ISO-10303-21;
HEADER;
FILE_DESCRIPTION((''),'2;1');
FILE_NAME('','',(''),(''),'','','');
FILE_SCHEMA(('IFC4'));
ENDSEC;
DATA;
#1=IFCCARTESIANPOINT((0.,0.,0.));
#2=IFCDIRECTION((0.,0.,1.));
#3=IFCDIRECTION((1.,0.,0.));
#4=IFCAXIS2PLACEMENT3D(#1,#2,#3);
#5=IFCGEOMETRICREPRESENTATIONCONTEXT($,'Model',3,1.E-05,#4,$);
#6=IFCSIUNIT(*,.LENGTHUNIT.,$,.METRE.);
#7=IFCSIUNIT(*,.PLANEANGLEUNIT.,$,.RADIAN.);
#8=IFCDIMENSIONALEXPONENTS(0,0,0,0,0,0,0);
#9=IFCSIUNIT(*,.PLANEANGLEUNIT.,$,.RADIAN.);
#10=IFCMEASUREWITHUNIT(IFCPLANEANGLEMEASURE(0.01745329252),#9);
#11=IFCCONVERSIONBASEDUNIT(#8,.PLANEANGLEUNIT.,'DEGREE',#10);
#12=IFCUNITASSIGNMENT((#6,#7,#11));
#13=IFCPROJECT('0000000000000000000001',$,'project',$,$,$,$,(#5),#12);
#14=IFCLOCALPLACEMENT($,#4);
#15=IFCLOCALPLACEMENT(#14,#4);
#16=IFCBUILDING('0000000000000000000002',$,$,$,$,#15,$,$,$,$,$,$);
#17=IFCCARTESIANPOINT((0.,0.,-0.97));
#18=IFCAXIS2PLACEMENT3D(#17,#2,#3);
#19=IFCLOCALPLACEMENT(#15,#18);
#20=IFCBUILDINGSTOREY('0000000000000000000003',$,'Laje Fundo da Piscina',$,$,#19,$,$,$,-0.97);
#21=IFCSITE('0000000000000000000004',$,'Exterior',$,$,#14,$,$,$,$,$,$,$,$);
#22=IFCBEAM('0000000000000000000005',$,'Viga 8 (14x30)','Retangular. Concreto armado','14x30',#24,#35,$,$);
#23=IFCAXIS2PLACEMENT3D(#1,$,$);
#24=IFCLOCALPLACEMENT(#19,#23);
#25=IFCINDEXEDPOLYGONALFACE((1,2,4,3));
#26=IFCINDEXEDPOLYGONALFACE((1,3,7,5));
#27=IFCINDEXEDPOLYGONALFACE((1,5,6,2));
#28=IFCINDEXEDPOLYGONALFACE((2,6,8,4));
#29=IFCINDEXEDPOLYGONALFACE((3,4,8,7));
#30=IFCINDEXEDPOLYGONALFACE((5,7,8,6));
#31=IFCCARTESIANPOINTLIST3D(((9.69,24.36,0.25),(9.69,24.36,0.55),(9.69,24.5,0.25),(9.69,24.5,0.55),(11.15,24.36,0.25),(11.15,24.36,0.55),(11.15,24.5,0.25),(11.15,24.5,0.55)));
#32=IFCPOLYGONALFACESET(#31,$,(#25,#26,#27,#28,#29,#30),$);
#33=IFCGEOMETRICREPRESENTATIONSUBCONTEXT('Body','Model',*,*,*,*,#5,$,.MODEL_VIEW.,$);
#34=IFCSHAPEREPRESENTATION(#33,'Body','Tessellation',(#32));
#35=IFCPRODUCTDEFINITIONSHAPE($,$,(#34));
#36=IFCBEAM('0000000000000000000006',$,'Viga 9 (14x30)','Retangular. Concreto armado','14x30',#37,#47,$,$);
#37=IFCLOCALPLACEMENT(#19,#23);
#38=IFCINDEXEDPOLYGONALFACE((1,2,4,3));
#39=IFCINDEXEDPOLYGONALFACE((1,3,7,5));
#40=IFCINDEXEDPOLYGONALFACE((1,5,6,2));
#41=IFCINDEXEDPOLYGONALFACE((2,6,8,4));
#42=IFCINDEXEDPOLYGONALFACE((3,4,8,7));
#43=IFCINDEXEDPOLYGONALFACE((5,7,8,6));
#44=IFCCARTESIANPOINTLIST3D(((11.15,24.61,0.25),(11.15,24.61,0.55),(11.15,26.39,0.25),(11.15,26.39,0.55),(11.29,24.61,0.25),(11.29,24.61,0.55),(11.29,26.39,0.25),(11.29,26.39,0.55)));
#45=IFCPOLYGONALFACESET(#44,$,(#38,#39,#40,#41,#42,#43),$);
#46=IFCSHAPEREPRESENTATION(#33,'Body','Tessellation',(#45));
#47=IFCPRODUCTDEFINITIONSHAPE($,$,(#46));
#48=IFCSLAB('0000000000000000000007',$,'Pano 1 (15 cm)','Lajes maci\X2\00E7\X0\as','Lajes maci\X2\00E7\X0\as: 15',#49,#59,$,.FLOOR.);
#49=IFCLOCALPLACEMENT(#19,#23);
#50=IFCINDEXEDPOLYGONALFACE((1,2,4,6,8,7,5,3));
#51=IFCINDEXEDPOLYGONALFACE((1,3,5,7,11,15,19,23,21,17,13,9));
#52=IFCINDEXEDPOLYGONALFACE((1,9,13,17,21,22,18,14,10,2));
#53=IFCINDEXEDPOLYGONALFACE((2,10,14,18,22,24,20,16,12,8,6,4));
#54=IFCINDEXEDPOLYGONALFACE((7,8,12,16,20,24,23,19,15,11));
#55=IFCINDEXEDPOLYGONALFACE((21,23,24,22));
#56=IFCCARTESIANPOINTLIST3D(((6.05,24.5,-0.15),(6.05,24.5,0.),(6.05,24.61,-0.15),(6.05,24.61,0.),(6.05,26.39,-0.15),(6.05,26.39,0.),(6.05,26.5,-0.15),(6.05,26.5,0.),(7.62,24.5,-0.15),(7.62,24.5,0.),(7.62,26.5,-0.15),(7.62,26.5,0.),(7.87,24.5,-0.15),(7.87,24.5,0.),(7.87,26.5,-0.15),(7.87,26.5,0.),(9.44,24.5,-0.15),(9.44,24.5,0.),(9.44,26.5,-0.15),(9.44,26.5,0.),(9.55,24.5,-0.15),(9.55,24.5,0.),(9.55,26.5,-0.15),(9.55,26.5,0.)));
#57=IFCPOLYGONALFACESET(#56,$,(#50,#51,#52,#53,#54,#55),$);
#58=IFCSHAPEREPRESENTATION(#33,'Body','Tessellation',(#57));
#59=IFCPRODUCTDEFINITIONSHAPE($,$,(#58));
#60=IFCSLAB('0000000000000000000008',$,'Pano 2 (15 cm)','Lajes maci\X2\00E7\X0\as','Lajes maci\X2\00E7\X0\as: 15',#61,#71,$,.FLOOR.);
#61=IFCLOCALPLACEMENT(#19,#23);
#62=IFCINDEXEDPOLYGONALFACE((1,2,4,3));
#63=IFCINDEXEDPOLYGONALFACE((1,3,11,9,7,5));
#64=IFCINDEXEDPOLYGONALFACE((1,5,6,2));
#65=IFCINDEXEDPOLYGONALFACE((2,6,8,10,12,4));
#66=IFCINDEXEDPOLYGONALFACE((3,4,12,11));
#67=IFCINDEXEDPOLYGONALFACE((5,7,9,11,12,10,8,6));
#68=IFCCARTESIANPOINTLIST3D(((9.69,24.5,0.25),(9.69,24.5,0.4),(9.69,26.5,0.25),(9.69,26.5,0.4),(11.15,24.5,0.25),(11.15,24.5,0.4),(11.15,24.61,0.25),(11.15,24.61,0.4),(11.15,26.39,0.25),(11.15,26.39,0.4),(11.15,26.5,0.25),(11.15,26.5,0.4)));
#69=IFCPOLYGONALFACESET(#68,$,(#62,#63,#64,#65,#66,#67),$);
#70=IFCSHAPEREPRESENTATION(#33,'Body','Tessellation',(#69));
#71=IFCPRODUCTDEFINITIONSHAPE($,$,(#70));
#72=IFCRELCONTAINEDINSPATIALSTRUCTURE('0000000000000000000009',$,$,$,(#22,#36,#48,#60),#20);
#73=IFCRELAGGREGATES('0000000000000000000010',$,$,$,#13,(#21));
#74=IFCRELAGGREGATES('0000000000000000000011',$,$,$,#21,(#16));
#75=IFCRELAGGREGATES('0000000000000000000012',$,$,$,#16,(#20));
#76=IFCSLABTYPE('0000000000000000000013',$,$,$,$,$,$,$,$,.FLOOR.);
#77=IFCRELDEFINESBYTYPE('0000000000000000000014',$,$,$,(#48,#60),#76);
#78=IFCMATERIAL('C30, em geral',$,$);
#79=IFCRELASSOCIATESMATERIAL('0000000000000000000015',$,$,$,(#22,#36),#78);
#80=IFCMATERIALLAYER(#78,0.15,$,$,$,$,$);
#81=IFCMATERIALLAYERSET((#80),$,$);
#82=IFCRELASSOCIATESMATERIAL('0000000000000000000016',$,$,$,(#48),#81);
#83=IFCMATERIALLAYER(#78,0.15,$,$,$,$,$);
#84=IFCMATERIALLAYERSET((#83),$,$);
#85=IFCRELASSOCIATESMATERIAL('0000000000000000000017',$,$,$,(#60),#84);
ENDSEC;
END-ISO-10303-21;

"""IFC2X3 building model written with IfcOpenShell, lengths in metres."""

from ifc_helpers import new_model, entity, si_unit, converted_unit, frame, frame_2d, origin_with_axes, place, context, subcontext, project, spatial, polyline, rectangle, outline, extrude, material, layer, layer_set, layer_usage, type_object, element, save


model = new_model("IFC2X3")

# Units and contexts
model_context = context("Model", 3, precision=1e-05, world=origin_with_axes())
body_context = subcontext(model_context, "Body", "Model", "MODEL_VIEW")
ifc_project = project(units=[si_unit("LENGTHUNIT", "METRE"), si_unit("PLANEANGLEUNIT", "RADIAN"), converted_unit("PLANEANGLEUNIT", "DEGREE", entity("IfcPlaneAngleMeasure", 0.01745329252), si_unit("PLANEANGLEUNIT", "RADIAN"), dimensions=[0, 0, 0, 0, 0, 0, 0])], contexts=[model_context])

# Site, building, storey
site_placement = place(None, origin_with_axes())
site = spatial("IfcSite", under=ifc_project, at=site_placement, Name="Exterior")
building_placement = place(site_placement, origin_with_axes())
building = spatial("IfcBuilding", under=site, at=building_placement)
storey_placement = place(building_placement, frame((0.0, 0.0, -0.97), z_axis=(0.0, 0.0, 1.0), x_axis=(1.0, 0.0, 0.0)))
storey = spatial("IfcBuildingStorey", under=building, at=storey_placement, Name="Laje Fundo da Piscina", Elevation=-0.97)

# Beams
ifc_material_1 = material(Name="C30, em geral")
for number, where, z_axis, x_axis, name in (
    (1, (9.69, 24.43, 0.55), (1.0, 0.0, 0.0), (0.0, 1.0, 0.0), "Viga 8 (14x30)"),
):
    element("IfcBeam", number, at=place(storey_placement, frame(where, z_axis=z_axis, x_axis=x_axis)), inside=storey, material=ifc_material_1, Name=name, Description="Retangular. Concreto armado", ObjectType="14x30", context=body_context, shape_type="SweptSolid", body=[
        extrude(rectangle(XDim=0.14, YDim=0.3, at=frame_2d((0.0, -0.15), x_axis=(1.0, 0.0))), origin_with_axes(), (0.0, 0.0, 1.0), 1.46),
    ])
beam_1_placement = place(storey_placement, frame((11.22, 26.39, 0.55), z_axis=(0.0, -1.0, 0.0), x_axis=(1.0, 0.0, 0.0)))
element("IfcBeam", 2, at=beam_1_placement, inside=storey, material=ifc_material_1, Name="Viga 9 (14x30)", Description="Retangular. Concreto armado", ObjectType="14x30", context=body_context, shape_type="SweptSolid", body=[
    extrude(rectangle(XDim=0.14, YDim=0.3, at=frame_2d((0.0, -0.15), x_axis=(1.0, 0.0))), origin_with_axes(), (0.0, 0.0, 1.0), 1.78),
])

# Slabs
ifc_layer_1 = layer(ifc_material_1, 0.15)
ifc_layer_set_1 = layer_set([ifc_layer_1])
ifc_layer_usage_1 = layer_usage(ifc_layer_set_1, "AXIS3", "POSITIVE", 0.0)
slab_type = type_object("IfcSlabType", PredefinedType="FLOOR")
slab_1_placement = place(storey_placement, frame((0.0, 0.0, -0.15), z_axis=(0.0, 0.0, 1.0), x_axis=(1.0, 0.0, 0.0)))
element("IfcSlab", 3, at=slab_1_placement, inside=storey, type_object=slab_type, material=ifc_layer_usage_1, Name="Pano 1 (15 cm)", Description="Lajes maciças", ObjectType="Lajes maciças: 15", PredefinedType="FLOOR", context=body_context, shape_type="SweptSolid", body=[
    extrude(outline(polyline([(9.44, 26.5), (7.87, 26.5), (7.62, 26.5), (6.05, 26.5), (6.05, 26.39), (6.05, 24.61), (6.05, 24.5), (7.62, 24.5), (7.87, 24.5), (9.44, 24.5), (9.55, 24.5), (9.55, 26.5), (9.44, 26.5)])), origin_with_axes(), (0.0, 0.0, 1.0), 0.15),
])
ifc_layer_2 = layer(ifc_material_1, 0.15)
ifc_layer_set_2 = layer_set([ifc_layer_2])
ifc_layer_usage_2 = layer_usage(ifc_layer_set_2, "AXIS3", "POSITIVE", 0.0)
slab_2_placement = place(storey_placement, frame((0.0, 0.0, 0.25), z_axis=(0.0, 0.0, 1.0), x_axis=(1.0, 0.0, 0.0)))
element("IfcSlab", 4, at=slab_2_placement, inside=storey, type_object=slab_type, material=ifc_layer_usage_2, Name="Pano 2 (15 cm)", Description="Lajes maciças", ObjectType="Lajes maciças: 15", PredefinedType="FLOOR", context=body_context, shape_type="SweptSolid", body=[
    extrude(outline(polyline([(11.15, 24.61), (11.15, 26.39), (11.15, 26.5), (9.69, 26.5), (9.69, 24.5), (11.15, 24.5), (11.15, 24.61)])), origin_with_axes(), (0.0, 0.0, 1.0), 0.15),
])

save(model, "model.ifc")
